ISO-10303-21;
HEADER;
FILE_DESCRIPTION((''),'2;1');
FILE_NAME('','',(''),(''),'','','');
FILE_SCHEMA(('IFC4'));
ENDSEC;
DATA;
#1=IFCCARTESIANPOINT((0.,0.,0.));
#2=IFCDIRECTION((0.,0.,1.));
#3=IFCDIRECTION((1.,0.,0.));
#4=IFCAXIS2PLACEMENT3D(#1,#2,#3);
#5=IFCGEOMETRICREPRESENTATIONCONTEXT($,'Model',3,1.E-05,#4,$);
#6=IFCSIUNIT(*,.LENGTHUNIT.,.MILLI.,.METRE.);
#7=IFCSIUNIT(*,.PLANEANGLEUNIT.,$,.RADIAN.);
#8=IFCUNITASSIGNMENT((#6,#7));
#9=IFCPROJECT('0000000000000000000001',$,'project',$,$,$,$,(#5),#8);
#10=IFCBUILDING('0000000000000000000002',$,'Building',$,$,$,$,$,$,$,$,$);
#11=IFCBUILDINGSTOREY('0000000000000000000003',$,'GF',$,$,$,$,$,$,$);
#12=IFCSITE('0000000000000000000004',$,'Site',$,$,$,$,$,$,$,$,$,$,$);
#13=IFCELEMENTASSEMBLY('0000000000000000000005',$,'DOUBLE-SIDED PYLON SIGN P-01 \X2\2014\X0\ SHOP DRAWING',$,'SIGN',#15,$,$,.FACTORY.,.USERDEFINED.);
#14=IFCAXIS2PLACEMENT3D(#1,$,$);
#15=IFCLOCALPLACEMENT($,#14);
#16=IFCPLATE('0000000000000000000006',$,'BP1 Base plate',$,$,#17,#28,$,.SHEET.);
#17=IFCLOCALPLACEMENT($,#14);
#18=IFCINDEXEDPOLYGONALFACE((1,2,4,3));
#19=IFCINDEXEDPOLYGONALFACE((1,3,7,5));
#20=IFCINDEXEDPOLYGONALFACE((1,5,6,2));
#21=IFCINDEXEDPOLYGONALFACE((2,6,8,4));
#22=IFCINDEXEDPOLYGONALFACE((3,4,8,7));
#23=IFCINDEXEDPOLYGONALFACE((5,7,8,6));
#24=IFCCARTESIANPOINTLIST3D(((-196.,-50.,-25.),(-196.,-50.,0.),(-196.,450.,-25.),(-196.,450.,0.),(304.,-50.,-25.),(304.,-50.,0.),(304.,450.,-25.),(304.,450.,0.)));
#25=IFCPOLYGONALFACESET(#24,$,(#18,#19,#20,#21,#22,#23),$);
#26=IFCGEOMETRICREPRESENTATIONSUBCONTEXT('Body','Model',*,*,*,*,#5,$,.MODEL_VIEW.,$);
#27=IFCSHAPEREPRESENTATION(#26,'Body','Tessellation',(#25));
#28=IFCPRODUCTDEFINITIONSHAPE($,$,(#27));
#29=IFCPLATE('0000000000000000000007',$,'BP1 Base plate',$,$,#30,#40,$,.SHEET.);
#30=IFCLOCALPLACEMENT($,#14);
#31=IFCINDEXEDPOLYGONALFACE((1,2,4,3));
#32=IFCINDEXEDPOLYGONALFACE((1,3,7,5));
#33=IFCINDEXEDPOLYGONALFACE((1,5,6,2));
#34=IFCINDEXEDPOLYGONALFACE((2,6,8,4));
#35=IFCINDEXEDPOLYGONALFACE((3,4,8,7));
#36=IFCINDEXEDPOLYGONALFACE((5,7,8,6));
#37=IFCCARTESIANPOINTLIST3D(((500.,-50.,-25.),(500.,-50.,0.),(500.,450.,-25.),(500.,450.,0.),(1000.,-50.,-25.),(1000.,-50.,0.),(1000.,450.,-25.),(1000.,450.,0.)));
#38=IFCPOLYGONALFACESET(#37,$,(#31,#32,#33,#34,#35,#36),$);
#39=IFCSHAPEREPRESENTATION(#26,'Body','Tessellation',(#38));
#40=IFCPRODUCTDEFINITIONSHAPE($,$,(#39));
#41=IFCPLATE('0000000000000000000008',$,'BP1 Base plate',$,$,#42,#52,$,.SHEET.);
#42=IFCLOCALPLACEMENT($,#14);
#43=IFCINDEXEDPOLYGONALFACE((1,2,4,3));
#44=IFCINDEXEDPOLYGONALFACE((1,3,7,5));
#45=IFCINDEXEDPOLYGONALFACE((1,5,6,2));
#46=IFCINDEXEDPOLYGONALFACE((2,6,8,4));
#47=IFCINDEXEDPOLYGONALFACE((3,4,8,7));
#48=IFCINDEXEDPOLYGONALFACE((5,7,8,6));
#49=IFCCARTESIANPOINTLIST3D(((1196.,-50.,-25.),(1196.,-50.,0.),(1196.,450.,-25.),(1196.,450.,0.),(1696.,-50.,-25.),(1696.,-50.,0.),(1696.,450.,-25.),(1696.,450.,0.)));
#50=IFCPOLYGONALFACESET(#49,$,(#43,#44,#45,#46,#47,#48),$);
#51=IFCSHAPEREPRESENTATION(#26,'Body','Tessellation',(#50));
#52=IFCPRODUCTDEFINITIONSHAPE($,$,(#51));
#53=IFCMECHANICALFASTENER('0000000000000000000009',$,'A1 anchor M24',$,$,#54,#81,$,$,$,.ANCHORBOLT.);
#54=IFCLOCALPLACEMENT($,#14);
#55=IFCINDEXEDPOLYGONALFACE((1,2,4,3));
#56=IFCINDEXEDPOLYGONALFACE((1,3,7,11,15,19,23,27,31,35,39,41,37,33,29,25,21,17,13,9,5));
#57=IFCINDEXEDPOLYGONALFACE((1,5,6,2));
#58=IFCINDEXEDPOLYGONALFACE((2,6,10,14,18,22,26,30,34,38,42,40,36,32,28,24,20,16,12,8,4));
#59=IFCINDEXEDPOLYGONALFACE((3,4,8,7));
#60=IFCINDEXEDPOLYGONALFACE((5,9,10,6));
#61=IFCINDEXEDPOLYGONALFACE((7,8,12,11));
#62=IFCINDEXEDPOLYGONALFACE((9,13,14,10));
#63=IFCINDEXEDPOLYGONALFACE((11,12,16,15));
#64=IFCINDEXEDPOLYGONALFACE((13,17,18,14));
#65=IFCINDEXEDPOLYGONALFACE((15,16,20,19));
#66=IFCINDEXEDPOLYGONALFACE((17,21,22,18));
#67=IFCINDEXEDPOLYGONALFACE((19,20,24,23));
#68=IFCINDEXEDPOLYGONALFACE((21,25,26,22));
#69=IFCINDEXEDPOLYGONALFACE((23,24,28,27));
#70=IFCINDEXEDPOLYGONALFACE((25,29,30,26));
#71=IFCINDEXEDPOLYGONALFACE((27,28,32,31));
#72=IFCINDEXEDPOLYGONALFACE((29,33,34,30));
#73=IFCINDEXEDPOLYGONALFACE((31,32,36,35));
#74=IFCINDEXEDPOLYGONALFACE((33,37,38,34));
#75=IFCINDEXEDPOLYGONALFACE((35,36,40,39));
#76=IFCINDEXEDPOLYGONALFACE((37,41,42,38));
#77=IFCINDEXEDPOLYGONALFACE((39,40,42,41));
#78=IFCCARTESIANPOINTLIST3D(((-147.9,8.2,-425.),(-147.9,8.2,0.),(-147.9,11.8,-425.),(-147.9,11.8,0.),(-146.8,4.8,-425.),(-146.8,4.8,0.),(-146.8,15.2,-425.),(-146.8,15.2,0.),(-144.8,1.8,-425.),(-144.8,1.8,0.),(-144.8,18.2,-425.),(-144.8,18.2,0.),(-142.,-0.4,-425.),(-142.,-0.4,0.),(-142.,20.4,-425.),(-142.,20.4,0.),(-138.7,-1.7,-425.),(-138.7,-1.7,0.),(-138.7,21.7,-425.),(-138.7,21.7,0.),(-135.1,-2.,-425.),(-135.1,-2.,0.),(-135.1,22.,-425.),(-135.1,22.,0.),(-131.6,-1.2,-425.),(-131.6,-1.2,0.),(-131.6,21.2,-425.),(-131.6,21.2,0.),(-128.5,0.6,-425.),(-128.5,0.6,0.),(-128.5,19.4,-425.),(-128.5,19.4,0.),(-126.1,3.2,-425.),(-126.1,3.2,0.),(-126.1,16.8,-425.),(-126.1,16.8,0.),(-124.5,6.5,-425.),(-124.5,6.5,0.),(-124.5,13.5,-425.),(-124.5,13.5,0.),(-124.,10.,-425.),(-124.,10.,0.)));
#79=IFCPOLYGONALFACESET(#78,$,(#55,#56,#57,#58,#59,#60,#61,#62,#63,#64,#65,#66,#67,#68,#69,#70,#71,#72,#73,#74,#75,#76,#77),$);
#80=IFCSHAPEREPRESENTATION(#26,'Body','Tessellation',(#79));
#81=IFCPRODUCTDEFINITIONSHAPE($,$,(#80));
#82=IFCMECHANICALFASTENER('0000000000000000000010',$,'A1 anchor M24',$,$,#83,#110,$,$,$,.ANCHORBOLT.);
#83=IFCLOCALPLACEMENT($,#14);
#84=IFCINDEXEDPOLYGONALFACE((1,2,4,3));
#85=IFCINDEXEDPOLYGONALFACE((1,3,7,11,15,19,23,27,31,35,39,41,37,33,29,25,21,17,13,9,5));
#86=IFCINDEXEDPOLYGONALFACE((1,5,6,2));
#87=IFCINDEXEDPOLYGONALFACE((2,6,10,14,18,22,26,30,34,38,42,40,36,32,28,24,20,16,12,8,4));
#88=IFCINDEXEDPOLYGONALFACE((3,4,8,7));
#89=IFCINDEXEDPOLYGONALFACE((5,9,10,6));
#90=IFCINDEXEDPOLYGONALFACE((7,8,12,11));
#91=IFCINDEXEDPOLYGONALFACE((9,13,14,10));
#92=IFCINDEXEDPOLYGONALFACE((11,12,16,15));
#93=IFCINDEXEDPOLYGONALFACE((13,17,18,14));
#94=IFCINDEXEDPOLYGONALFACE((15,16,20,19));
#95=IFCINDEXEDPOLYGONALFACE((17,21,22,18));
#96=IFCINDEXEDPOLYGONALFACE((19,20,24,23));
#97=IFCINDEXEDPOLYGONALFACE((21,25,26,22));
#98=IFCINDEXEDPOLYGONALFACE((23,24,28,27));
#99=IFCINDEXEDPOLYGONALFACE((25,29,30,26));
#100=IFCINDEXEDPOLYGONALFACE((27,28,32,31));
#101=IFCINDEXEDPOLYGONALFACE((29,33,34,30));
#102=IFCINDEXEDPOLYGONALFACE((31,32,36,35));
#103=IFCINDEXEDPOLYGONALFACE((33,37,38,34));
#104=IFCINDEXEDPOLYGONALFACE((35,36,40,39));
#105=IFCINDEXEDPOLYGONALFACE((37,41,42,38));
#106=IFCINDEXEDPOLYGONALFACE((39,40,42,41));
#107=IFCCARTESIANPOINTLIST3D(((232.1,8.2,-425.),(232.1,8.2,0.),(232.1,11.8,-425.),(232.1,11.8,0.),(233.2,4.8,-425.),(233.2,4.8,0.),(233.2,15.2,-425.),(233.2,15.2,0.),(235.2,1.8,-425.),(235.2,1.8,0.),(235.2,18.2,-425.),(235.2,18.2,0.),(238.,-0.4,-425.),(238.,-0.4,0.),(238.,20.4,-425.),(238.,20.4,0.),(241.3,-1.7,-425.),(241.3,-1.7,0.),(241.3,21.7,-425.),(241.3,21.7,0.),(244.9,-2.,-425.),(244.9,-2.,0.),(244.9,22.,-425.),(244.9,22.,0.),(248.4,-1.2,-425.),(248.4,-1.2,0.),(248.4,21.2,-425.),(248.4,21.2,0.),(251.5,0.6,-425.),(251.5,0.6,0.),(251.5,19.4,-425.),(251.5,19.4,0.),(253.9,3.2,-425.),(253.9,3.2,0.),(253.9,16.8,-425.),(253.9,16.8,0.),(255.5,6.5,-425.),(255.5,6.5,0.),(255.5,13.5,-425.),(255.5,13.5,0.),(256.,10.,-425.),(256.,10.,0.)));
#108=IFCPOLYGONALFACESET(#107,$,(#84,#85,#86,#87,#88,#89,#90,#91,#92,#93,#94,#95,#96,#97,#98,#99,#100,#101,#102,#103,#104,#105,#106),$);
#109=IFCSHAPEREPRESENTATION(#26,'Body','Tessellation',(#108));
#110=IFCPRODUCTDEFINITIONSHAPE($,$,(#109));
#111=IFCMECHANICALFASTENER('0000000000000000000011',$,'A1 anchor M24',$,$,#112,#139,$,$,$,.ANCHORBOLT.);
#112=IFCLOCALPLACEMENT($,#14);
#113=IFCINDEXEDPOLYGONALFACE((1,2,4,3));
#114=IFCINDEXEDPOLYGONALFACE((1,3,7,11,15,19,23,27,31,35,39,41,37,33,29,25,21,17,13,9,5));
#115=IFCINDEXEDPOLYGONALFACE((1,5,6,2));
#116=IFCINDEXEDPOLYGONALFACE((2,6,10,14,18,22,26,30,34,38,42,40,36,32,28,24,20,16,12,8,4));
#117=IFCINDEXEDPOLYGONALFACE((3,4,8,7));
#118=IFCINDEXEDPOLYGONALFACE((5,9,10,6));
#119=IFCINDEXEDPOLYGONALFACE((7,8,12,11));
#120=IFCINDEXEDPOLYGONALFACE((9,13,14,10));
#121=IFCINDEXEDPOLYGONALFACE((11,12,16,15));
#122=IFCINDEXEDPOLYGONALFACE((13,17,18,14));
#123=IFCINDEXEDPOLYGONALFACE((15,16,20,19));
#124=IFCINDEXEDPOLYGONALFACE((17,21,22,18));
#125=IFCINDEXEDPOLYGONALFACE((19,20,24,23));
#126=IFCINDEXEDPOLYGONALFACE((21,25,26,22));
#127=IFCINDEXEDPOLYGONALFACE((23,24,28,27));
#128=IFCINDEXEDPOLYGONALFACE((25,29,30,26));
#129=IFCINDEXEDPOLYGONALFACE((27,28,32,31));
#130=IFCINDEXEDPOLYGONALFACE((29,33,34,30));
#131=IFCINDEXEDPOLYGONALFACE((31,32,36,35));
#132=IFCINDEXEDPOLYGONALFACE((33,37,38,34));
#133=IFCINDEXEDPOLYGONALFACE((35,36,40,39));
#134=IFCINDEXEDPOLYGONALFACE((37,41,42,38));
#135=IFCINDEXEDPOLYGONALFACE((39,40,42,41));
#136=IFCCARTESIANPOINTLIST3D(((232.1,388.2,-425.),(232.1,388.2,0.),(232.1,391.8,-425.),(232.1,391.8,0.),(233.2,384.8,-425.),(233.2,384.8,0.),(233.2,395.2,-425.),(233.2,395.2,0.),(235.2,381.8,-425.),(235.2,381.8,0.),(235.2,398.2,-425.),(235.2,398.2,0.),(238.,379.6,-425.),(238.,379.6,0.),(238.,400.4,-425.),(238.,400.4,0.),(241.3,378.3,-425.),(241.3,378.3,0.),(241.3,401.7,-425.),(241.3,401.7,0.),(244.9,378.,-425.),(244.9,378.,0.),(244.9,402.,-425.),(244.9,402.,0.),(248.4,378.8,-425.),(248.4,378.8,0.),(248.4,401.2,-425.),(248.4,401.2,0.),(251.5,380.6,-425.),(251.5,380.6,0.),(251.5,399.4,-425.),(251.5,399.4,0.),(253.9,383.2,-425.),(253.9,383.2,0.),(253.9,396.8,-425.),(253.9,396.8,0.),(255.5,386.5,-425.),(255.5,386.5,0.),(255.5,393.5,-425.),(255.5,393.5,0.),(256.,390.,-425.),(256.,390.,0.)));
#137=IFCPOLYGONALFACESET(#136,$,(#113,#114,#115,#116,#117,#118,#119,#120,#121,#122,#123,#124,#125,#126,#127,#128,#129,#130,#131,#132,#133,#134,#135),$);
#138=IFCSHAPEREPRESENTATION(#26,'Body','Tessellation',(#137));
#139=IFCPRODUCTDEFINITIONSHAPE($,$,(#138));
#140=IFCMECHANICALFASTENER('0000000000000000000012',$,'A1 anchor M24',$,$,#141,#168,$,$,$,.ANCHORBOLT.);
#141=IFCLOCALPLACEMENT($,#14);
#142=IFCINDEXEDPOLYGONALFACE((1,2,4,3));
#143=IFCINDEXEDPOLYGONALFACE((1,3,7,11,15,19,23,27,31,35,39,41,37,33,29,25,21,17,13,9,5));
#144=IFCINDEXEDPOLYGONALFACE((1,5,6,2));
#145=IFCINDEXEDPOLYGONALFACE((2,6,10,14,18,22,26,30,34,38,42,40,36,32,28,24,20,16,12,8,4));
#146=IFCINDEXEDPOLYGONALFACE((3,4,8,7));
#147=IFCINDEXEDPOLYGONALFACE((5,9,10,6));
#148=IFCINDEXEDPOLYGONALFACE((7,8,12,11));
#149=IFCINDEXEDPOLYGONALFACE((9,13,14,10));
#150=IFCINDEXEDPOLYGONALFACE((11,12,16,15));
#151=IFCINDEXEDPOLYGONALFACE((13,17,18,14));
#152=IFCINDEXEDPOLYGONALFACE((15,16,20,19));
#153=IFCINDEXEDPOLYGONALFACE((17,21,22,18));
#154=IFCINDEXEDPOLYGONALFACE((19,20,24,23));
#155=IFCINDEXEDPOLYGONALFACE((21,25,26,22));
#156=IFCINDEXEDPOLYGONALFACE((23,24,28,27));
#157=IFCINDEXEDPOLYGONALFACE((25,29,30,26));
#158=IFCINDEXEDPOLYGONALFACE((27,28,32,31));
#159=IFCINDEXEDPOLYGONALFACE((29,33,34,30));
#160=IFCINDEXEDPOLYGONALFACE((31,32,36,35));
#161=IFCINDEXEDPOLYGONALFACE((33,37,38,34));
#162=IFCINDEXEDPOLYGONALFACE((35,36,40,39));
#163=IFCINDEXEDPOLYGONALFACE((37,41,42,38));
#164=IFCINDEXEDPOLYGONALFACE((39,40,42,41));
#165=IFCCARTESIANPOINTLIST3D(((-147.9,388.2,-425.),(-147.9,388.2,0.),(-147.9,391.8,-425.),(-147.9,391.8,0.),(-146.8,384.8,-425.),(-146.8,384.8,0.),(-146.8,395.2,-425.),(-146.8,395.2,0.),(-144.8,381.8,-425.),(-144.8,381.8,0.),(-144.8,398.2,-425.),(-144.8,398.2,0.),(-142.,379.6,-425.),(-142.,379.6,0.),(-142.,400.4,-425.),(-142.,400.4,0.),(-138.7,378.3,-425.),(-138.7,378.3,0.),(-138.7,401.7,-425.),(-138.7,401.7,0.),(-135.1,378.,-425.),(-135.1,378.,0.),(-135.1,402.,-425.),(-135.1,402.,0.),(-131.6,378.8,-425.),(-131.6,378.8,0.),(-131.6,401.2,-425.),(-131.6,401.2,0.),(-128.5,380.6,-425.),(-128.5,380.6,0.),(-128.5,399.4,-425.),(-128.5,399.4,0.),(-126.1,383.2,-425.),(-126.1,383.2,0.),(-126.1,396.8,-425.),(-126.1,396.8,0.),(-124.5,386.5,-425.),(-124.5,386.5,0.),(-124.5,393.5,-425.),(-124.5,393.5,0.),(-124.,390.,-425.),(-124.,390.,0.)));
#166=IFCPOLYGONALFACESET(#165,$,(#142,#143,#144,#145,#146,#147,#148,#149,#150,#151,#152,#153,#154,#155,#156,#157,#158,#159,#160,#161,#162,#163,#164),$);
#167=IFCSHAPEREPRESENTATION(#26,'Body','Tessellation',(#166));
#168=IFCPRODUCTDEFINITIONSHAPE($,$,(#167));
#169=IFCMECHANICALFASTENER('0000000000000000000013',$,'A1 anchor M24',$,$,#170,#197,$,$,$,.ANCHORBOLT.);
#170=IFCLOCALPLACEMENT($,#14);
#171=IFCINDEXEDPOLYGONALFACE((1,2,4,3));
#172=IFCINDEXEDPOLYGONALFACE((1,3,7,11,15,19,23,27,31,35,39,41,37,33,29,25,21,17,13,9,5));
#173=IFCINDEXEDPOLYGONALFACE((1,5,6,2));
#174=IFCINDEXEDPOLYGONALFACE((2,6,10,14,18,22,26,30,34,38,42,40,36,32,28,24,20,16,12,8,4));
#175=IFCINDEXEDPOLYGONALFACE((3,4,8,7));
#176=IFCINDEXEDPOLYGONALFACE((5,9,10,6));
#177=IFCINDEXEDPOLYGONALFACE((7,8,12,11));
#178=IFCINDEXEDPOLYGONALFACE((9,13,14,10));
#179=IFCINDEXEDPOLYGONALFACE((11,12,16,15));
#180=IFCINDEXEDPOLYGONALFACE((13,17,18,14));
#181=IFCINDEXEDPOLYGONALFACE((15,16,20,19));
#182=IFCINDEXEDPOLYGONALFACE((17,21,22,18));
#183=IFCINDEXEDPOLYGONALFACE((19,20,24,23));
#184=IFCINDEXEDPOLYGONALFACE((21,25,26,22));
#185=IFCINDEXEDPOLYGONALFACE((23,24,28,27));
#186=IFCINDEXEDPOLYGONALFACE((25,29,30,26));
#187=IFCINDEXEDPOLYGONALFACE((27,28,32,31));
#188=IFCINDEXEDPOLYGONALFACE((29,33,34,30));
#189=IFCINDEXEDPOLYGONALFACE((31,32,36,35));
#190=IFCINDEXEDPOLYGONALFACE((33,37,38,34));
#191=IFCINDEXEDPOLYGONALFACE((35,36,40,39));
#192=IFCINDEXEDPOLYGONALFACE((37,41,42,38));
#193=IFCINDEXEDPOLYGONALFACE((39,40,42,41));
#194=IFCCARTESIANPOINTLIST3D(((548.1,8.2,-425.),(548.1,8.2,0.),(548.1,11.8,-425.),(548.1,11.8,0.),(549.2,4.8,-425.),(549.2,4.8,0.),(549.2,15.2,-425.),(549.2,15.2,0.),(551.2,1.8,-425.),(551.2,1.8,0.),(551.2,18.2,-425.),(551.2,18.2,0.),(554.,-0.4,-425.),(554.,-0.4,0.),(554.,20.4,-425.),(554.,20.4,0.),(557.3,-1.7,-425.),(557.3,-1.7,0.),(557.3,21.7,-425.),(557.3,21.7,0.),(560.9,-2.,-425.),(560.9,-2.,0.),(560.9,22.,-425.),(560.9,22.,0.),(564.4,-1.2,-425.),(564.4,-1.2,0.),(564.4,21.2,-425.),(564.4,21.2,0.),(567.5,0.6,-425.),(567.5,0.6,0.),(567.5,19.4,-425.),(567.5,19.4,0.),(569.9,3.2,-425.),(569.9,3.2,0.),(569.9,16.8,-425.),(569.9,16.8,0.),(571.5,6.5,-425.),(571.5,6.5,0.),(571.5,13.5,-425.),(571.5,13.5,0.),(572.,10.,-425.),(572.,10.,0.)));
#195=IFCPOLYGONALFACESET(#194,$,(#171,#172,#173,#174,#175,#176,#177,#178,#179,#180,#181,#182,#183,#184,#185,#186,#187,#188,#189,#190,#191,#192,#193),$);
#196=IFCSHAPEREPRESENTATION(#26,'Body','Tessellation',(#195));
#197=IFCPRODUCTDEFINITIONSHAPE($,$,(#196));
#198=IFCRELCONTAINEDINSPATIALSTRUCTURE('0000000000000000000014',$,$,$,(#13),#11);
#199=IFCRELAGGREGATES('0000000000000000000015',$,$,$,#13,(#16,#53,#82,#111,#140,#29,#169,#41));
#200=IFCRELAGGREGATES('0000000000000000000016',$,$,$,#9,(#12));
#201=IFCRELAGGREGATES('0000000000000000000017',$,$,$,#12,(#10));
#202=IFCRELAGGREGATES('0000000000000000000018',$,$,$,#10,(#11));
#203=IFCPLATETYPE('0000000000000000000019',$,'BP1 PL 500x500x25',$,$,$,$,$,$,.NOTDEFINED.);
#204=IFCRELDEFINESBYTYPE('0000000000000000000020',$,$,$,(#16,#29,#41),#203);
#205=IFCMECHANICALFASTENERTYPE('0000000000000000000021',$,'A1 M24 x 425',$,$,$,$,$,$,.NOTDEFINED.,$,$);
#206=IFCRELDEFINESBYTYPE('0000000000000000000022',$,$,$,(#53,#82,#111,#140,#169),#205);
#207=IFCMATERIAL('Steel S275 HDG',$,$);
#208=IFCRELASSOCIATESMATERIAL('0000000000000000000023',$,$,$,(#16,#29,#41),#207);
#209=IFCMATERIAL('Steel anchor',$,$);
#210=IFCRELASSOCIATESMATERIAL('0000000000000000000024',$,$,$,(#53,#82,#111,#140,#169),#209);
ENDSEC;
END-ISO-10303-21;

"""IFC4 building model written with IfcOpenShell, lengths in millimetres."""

from ifc_helpers import new_model, si_unit, frame, frame_2d, origin, origin_with_axes, place, context, subcontext, project, spatial, rectangle, circle, extrude, material, type_object, element, aggregate, save


model = new_model("IFC4")

# Units and contexts
model_context = context("Model", 3, precision=1e-05, world=origin_with_axes())
body_context = subcontext(model_context, "Body", "Model", "MODEL_VIEW")
ifc_project = project(units=[si_unit("LENGTHUNIT", "METRE", prefix="MILLI"), si_unit("PLANEANGLEUNIT", "RADIAN")], contexts=[model_context])

# Site, building, storey
site = spatial("IfcSite", under=ifc_project, Name="Site")
building = spatial("IfcBuilding", under=site, Name="Building")
storey = spatial("IfcBuildingStorey", under=building, Name="GF")

# Element assembly, plates, mechanical fasteners
assembly_placement = place(None, origin_with_axes())
assembly = element("IfcElementAssembly", 1, at=assembly_placement, inside=storey, Name="DOUBLE-SIDED PYLON SIGN P-01 — SHOP DRAWING", ObjectType="SIGN", AssemblyPlace="FACTORY", PredefinedType="USERDEFINED")
ifc_material_1 = material(Name="Steel S275 HDG")
plate_type_1 = type_object("IfcPlateType", Name="BP1 PL 500x500x25", PredefinedType="NOTDEFINED")
plate_1_placement = place(assembly_placement, frame((-196.0, -50.0, -25.0), z_axis=(0.0, 0.0, 1.0), x_axis=(1.0, 0.0, 0.0)))
plate_1 = element("IfcPlate", 2, at=plate_1_placement, type_object=plate_type_1, material=ifc_material_1, Name="BP1 Base plate", PredefinedType="SHEET", context=body_context, shape_type="SweptSolid", body=[
    extrude(rectangle(XDim=500.0, YDim=500.0, at=frame_2d((250.0, 250.0))), origin(), (0.0, 0.0, 1.0), 25.0),
])
plate_2_placement = place(assembly_placement, frame((500.0, -50.0, -25.0), z_axis=(0.0, 0.0, 1.0), x_axis=(1.0, 0.0, 0.0)))
plate_2 = element("IfcPlate", 3, at=plate_2_placement, type_object=plate_type_1, material=ifc_material_1, Name="BP1 Base plate", PredefinedType="SHEET", context=body_context, shape_type="SweptSolid", body=[
    extrude(rectangle(XDim=500.0, YDim=500.0, at=frame_2d((250.0, 250.0))), origin(), (0.0, 0.0, 1.0), 25.0),
])
plate_3_placement = place(assembly_placement, frame((1196.0, -50.0, -25.0), z_axis=(0.0, 0.0, 1.0), x_axis=(1.0, 0.0, 0.0)))
plate_3 = element("IfcPlate", 4, at=plate_3_placement, type_object=plate_type_1, material=ifc_material_1, Name="BP1 Base plate", PredefinedType="SHEET", context=body_context, shape_type="SweptSolid", body=[
    extrude(rectangle(XDim=500.0, YDim=500.0, at=frame_2d((250.0, 250.0))), origin(), (0.0, 0.0, 1.0), 25.0),
])
ifc_material_2 = material(Name="Steel anchor")
mechanical_fastener_type = type_object("IfcMechanicalFastenerType", Name="A1 M24 x 425", PredefinedType="NOTDEFINED")
mechanical_fastener_1_placement = place(assembly_placement, frame((-136.0, 10.0, -425.0), z_axis=(0.0, 0.0, 1.0), x_axis=(1.0, 0.0, 0.0)))
mechanical_fastener_1 = element("IfcMechanicalFastener", 5, at=mechanical_fastener_1_placement, type_object=mechanical_fastener_type, material=ifc_material_2, Name="A1 anchor M24", PredefinedType="ANCHORBOLT", context=body_context, shape_type="SweptSolid", body=[
    extrude(circle(Radius=12.0), origin(), (0.0, 0.0, 1.0), 425.0),
])
mechanical_fastener_2_placement = place(assembly_placement, frame((244.0, 10.0, -425.0), z_axis=(0.0, 0.0, 1.0), x_axis=(1.0, 0.0, 0.0)))
mechanical_fastener_2 = element("IfcMechanicalFastener", 6, at=mechanical_fastener_2_placement, type_object=mechanical_fastener_type, material=ifc_material_2, Name="A1 anchor M24", PredefinedType="ANCHORBOLT", context=body_context, shape_type="SweptSolid", body=[
    extrude(circle(Radius=12.0), origin(), (0.0, 0.0, 1.0), 425.0),
])
mechanical_fastener_3_placement = place(assembly_placement, frame((244.0, 390.0, -425.0), z_axis=(0.0, 0.0, 1.0), x_axis=(1.0, 0.0, 0.0)))
mechanical_fastener_3 = element("IfcMechanicalFastener", 7, at=mechanical_fastener_3_placement, type_object=mechanical_fastener_type, material=ifc_material_2, Name="A1 anchor M24", PredefinedType="ANCHORBOLT", context=body_context, shape_type="SweptSolid", body=[
    extrude(circle(Radius=12.0), origin(), (0.0, 0.0, 1.0), 425.0),
])
mechanical_fastener_4_placement = place(assembly_placement, frame((-136.0, 390.0, -425.0), z_axis=(0.0, 0.0, 1.0), x_axis=(1.0, 0.0, 0.0)))
mechanical_fastener_4 = element("IfcMechanicalFastener", 8, at=mechanical_fastener_4_placement, type_object=mechanical_fastener_type, material=ifc_material_2, Name="A1 anchor M24", PredefinedType="ANCHORBOLT", context=body_context, shape_type="SweptSolid", body=[
    extrude(circle(Radius=12.0), origin(), (0.0, 0.0, 1.0), 425.0),
])
mechanical_fastener_5_placement = place(assembly_placement, frame((560.0, 10.0, -425.0), z_axis=(0.0, 0.0, 1.0), x_axis=(1.0, 0.0, 0.0)))
mechanical_fastener_5 = element("IfcMechanicalFastener", 9, at=mechanical_fastener_5_placement, type_object=mechanical_fastener_type, material=ifc_material_2, Name="A1 anchor M24", PredefinedType="ANCHORBOLT", context=body_context, shape_type="SweptSolid", body=[
    extrude(circle(Radius=12.0), origin(), (0.0, 0.0, 1.0), 425.0),
])
aggregate(assembly, [plate_1, mechanical_fastener_1, mechanical_fastener_2, mechanical_fastener_3, mechanical_fastener_4, plate_2, mechanical_fastener_5, plate_3])

save(model, "model.ifc")
